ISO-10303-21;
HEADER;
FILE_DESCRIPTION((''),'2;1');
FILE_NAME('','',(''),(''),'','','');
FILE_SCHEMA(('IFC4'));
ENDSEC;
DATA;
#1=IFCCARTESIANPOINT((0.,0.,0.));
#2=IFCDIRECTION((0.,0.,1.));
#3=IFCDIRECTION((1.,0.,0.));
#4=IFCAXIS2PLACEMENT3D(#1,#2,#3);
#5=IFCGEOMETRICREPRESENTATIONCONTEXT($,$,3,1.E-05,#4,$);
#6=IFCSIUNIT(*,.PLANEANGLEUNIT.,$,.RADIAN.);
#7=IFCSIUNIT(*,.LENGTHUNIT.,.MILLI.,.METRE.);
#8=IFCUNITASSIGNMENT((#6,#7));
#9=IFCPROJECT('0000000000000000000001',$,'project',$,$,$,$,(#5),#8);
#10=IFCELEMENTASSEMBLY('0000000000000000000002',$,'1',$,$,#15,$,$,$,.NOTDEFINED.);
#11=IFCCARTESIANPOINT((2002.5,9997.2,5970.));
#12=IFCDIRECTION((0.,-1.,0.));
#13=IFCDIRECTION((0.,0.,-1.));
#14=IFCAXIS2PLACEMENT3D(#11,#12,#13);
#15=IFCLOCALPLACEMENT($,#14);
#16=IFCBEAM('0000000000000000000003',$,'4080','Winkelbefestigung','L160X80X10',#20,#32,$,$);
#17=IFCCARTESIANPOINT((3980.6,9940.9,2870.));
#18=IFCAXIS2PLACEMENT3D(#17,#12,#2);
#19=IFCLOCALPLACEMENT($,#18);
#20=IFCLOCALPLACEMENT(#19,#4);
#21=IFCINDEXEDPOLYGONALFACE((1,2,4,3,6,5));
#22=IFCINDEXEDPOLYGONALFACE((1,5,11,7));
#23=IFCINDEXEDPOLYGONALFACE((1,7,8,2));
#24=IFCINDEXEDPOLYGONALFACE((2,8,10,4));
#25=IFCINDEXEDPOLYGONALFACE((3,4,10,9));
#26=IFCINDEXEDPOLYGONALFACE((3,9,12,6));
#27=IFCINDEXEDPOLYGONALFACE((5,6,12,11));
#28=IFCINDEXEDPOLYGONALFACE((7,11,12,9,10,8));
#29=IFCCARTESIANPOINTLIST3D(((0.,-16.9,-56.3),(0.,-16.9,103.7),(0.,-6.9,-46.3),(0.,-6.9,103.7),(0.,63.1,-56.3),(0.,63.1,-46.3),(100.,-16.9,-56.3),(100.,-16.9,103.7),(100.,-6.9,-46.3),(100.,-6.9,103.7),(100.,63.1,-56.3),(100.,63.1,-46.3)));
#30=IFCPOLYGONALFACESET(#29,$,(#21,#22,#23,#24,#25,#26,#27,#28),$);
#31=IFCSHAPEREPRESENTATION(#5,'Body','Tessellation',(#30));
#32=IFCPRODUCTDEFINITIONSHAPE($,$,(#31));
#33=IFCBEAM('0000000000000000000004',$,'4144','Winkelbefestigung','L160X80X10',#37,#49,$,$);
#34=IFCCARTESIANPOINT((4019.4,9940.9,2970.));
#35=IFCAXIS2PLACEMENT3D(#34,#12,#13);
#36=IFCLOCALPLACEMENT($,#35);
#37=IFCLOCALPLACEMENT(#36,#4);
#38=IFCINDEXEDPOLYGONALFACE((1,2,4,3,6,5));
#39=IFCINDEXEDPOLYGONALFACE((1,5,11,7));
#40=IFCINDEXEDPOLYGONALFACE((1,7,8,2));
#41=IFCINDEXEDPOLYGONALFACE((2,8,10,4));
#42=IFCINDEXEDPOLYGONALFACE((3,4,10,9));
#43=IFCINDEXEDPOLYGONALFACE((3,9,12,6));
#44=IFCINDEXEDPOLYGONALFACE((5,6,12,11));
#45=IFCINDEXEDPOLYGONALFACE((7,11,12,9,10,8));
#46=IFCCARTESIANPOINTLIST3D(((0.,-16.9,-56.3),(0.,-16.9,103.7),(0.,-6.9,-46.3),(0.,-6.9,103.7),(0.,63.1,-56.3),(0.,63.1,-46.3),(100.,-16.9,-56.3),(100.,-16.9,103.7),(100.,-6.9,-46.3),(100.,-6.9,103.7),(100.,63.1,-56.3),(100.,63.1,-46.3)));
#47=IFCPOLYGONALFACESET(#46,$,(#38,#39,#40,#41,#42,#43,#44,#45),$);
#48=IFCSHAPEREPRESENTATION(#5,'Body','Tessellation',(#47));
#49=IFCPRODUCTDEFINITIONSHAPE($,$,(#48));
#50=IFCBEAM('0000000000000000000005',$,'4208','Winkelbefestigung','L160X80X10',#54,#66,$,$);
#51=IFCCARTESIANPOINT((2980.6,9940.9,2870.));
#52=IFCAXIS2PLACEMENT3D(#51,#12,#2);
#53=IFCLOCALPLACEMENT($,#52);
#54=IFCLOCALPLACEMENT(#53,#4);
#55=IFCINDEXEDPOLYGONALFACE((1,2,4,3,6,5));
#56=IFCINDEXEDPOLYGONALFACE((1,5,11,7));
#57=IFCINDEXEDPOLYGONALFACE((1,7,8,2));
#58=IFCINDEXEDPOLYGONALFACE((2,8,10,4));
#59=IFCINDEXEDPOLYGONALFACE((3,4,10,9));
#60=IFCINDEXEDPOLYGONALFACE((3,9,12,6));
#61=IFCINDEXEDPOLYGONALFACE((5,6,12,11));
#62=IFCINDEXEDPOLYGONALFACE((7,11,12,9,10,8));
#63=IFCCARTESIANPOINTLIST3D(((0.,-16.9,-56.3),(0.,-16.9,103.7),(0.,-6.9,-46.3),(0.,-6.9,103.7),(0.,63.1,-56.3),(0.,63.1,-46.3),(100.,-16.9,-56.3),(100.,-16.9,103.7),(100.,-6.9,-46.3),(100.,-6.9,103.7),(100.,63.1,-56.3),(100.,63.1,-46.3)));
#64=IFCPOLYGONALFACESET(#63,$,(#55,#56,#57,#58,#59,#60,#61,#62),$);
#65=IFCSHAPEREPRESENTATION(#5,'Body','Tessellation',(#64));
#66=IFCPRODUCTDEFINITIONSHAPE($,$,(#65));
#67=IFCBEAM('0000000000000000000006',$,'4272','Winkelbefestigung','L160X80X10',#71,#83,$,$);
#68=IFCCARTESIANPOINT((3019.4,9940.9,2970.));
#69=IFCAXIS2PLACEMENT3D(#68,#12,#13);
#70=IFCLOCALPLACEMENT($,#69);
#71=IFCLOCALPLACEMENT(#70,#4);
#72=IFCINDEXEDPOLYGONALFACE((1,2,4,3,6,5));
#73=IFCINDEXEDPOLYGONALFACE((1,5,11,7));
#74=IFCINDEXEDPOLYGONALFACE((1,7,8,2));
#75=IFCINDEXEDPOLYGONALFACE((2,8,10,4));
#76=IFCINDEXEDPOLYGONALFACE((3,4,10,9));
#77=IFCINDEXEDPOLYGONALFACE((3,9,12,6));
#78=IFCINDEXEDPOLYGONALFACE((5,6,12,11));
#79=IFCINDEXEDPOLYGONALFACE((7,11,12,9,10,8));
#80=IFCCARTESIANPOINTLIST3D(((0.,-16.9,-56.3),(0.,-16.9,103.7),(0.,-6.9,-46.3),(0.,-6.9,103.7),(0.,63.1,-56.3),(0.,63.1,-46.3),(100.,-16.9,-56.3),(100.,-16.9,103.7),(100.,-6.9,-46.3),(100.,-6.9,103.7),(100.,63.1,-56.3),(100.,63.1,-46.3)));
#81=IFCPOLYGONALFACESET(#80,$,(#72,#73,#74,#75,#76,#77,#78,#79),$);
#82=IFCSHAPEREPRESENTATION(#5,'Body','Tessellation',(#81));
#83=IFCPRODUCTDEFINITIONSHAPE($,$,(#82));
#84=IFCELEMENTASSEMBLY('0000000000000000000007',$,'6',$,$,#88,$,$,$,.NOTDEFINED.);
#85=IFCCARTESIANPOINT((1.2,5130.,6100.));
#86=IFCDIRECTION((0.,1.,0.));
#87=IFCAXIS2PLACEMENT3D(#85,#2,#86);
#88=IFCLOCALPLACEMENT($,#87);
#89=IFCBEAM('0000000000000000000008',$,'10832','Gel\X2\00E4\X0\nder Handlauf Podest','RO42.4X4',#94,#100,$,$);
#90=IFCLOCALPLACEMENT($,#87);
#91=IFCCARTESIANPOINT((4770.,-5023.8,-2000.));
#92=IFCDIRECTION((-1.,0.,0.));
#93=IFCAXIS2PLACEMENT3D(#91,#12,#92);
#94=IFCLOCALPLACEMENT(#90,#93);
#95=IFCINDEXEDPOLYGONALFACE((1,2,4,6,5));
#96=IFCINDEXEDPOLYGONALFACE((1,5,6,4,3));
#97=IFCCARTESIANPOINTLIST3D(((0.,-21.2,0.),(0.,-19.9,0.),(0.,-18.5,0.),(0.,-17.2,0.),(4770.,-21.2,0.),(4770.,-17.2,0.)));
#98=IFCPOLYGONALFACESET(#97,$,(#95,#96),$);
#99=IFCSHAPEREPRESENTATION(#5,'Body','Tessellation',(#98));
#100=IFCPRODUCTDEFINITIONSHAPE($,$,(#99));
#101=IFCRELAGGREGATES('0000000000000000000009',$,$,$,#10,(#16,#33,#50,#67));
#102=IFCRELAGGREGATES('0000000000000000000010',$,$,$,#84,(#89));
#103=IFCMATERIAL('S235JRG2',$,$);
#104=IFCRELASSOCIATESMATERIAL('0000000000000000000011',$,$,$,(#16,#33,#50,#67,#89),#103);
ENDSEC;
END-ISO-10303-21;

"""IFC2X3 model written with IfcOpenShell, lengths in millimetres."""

from ifc_helpers import new_model, si_unit, frame, origin_with_axes, place, context, project, polyline, outline, extrude, material, element, aggregate, save


model = new_model("IFC2X3")

# Units and contexts
context_of_model = context(None, 3, precision=1e-05, world=origin_with_axes())
ifc_project = project(units=[si_unit("PLANEANGLEUNIT", "RADIAN"), si_unit("LENGTHUNIT", "METRE", prefix="MILLI")], contexts=[context_of_model])

# Shared definitions
ifc_material = material(Name="S235JRG2")

# Element assembly, beams
assembly_1_placement = place(None, frame((2002.5, 9997.2, 5970.0), z_axis=(0.0, -1.0, 0.0), x_axis=(0.0, 0.0, -1.0)))
assembly_1 = element("IfcElementAssembly", 1, at=assembly_1_placement, Name="1", PredefinedType="NOTDEFINED")
placement_1 = place(None, frame((3980.6, 9940.9, 2870.0), z_axis=(0.0, -1.0, 0.0), x_axis=(0.0, 0.0, 1.0)))
beam_1_placement = place(placement_1, origin_with_axes())
beam_1 = element("IfcBeam", 2, at=beam_1_placement, material=ifc_material, Name="4080", Description="Winkelbefestigung", ObjectType="L160X80X10", context=context_of_model, shape_type="SweptSolid", body=[
    extrude(outline(polyline([(-16.9, 103.7), (-16.9, -56.3), (63.1, -56.3), (63.1, -46.3), (-6.9, -46.3), (-6.9, 103.7), (-16.9, 103.7), (-16.9, 103.7)])), frame((0.0, 0.0, 0.0), z_axis=(1.0, 0.0, 0.0), x_axis=(0.0, 1.0, 0.0)), (0.0, 0.0, 1.0), 100.0),
])
placement_2 = place(None, frame((4019.4, 9940.9, 2970.0), z_axis=(0.0, -1.0, 0.0), x_axis=(0.0, 0.0, -1.0)))
beam_2_placement = place(placement_2, origin_with_axes())
beam_2 = element("IfcBeam", 3, at=beam_2_placement, material=ifc_material, Name="4144", Description="Winkelbefestigung", ObjectType="L160X80X10", context=context_of_model, shape_type="SweptSolid", body=[
    extrude(outline(polyline([(-16.9, 103.7), (-16.9, -56.3), (63.1, -56.3), (63.1, -46.3), (-6.9, -46.3), (-6.9, 103.7), (-16.9, 103.7), (-16.9, 103.7)])), frame((0.0, 0.0, 0.0), z_axis=(1.0, 0.0, 0.0), x_axis=(0.0, 1.0, 0.0)), (0.0, 0.0, 1.0), 100.0),
])
placement_3 = place(None, frame((2980.6, 9940.9, 2870.0), z_axis=(0.0, -1.0, 0.0), x_axis=(0.0, 0.0, 1.0)))
beam_3_placement = place(placement_3, origin_with_axes())
beam_3 = element("IfcBeam", 4, at=beam_3_placement, material=ifc_material, Name="4208", Description="Winkelbefestigung", ObjectType="L160X80X10", context=context_of_model, shape_type="SweptSolid", body=[
    extrude(outline(polyline([(-16.9, 103.7), (-16.9, -56.3), (63.1, -56.3), (63.1, -46.3), (-6.9, -46.3), (-6.9, 103.7), (-16.9, 103.7), (-16.9, 103.7)])), frame((0.0, 0.0, 0.0), z_axis=(1.0, 0.0, 0.0), x_axis=(0.0, 1.0, 0.0)), (0.0, 0.0, 1.0), 100.0),
])
placement_4 = place(None, frame((3019.4, 9940.9, 2970.0), z_axis=(0.0, -1.0, 0.0), x_axis=(0.0, 0.0, -1.0)))
beam_4_placement = place(placement_4, origin_with_axes())
beam_4 = element("IfcBeam", 5, at=beam_4_placement, material=ifc_material, Name="4272", Description="Winkelbefestigung", ObjectType="L160X80X10", context=context_of_model, shape_type="SweptSolid", body=[
    extrude(outline(polyline([(-16.9, 103.7), (-16.9, -56.3), (63.1, -56.3), (63.1, -46.3), (-6.9, -46.3), (-6.9, 103.7), (-16.9, 103.7), (-16.9, 103.7)])), frame((0.0, 0.0, 0.0), z_axis=(1.0, 0.0, 0.0), x_axis=(0.0, 1.0, 0.0)), (0.0, 0.0, 1.0), 100.0),
])
aggregate(assembly_1, [beam_1, beam_2, beam_3, beam_4])

# Element assembly, beam
assembly_2_placement = place(None, frame((1.2, 5130.0, 6100.0), z_axis=(0.0, 0.0, 1.0), x_axis=(0.0, 1.0, 0.0)))
assembly_2 = element("IfcElementAssembly", 6, at=assembly_2_placement, Name="6", PredefinedType="NOTDEFINED")
placement_5 = place(None, frame((1.2, 5130.0, 6100.0), z_axis=(0.0, 0.0, 1.0), x_axis=(0.0, 1.0, 0.0)))
beam_5_placement = place(placement_5, frame((4770.0, -5023.8, -2000.0), z_axis=(0.0, -1.0, 0.0), x_axis=(-1.0, 0.0, 0.0)))
beam_5 = element("IfcBeam", 7, at=beam_5_placement, material=ifc_material, Name="10832", Description="Geländer Handlauf Podest", ObjectType="RO42.4X4", context=context_of_model, shape_type="SweptSolid", body=[
    extrude(outline(polyline([(-21.2, 0.0), (-21.2, 0.0), (-17.2, 0.0), (-17.2, 0.0), (-21.2, 0.0)])), frame((0.0, 0.0, 0.0), z_axis=(1.0, 0.0, 0.0), x_axis=(0.0, 1.0, 0.0)), (0.0, 0.0, 1.0), 4770.0),
])
aggregate(assembly_2, [beam_5])

save(model, "model.ifc")
